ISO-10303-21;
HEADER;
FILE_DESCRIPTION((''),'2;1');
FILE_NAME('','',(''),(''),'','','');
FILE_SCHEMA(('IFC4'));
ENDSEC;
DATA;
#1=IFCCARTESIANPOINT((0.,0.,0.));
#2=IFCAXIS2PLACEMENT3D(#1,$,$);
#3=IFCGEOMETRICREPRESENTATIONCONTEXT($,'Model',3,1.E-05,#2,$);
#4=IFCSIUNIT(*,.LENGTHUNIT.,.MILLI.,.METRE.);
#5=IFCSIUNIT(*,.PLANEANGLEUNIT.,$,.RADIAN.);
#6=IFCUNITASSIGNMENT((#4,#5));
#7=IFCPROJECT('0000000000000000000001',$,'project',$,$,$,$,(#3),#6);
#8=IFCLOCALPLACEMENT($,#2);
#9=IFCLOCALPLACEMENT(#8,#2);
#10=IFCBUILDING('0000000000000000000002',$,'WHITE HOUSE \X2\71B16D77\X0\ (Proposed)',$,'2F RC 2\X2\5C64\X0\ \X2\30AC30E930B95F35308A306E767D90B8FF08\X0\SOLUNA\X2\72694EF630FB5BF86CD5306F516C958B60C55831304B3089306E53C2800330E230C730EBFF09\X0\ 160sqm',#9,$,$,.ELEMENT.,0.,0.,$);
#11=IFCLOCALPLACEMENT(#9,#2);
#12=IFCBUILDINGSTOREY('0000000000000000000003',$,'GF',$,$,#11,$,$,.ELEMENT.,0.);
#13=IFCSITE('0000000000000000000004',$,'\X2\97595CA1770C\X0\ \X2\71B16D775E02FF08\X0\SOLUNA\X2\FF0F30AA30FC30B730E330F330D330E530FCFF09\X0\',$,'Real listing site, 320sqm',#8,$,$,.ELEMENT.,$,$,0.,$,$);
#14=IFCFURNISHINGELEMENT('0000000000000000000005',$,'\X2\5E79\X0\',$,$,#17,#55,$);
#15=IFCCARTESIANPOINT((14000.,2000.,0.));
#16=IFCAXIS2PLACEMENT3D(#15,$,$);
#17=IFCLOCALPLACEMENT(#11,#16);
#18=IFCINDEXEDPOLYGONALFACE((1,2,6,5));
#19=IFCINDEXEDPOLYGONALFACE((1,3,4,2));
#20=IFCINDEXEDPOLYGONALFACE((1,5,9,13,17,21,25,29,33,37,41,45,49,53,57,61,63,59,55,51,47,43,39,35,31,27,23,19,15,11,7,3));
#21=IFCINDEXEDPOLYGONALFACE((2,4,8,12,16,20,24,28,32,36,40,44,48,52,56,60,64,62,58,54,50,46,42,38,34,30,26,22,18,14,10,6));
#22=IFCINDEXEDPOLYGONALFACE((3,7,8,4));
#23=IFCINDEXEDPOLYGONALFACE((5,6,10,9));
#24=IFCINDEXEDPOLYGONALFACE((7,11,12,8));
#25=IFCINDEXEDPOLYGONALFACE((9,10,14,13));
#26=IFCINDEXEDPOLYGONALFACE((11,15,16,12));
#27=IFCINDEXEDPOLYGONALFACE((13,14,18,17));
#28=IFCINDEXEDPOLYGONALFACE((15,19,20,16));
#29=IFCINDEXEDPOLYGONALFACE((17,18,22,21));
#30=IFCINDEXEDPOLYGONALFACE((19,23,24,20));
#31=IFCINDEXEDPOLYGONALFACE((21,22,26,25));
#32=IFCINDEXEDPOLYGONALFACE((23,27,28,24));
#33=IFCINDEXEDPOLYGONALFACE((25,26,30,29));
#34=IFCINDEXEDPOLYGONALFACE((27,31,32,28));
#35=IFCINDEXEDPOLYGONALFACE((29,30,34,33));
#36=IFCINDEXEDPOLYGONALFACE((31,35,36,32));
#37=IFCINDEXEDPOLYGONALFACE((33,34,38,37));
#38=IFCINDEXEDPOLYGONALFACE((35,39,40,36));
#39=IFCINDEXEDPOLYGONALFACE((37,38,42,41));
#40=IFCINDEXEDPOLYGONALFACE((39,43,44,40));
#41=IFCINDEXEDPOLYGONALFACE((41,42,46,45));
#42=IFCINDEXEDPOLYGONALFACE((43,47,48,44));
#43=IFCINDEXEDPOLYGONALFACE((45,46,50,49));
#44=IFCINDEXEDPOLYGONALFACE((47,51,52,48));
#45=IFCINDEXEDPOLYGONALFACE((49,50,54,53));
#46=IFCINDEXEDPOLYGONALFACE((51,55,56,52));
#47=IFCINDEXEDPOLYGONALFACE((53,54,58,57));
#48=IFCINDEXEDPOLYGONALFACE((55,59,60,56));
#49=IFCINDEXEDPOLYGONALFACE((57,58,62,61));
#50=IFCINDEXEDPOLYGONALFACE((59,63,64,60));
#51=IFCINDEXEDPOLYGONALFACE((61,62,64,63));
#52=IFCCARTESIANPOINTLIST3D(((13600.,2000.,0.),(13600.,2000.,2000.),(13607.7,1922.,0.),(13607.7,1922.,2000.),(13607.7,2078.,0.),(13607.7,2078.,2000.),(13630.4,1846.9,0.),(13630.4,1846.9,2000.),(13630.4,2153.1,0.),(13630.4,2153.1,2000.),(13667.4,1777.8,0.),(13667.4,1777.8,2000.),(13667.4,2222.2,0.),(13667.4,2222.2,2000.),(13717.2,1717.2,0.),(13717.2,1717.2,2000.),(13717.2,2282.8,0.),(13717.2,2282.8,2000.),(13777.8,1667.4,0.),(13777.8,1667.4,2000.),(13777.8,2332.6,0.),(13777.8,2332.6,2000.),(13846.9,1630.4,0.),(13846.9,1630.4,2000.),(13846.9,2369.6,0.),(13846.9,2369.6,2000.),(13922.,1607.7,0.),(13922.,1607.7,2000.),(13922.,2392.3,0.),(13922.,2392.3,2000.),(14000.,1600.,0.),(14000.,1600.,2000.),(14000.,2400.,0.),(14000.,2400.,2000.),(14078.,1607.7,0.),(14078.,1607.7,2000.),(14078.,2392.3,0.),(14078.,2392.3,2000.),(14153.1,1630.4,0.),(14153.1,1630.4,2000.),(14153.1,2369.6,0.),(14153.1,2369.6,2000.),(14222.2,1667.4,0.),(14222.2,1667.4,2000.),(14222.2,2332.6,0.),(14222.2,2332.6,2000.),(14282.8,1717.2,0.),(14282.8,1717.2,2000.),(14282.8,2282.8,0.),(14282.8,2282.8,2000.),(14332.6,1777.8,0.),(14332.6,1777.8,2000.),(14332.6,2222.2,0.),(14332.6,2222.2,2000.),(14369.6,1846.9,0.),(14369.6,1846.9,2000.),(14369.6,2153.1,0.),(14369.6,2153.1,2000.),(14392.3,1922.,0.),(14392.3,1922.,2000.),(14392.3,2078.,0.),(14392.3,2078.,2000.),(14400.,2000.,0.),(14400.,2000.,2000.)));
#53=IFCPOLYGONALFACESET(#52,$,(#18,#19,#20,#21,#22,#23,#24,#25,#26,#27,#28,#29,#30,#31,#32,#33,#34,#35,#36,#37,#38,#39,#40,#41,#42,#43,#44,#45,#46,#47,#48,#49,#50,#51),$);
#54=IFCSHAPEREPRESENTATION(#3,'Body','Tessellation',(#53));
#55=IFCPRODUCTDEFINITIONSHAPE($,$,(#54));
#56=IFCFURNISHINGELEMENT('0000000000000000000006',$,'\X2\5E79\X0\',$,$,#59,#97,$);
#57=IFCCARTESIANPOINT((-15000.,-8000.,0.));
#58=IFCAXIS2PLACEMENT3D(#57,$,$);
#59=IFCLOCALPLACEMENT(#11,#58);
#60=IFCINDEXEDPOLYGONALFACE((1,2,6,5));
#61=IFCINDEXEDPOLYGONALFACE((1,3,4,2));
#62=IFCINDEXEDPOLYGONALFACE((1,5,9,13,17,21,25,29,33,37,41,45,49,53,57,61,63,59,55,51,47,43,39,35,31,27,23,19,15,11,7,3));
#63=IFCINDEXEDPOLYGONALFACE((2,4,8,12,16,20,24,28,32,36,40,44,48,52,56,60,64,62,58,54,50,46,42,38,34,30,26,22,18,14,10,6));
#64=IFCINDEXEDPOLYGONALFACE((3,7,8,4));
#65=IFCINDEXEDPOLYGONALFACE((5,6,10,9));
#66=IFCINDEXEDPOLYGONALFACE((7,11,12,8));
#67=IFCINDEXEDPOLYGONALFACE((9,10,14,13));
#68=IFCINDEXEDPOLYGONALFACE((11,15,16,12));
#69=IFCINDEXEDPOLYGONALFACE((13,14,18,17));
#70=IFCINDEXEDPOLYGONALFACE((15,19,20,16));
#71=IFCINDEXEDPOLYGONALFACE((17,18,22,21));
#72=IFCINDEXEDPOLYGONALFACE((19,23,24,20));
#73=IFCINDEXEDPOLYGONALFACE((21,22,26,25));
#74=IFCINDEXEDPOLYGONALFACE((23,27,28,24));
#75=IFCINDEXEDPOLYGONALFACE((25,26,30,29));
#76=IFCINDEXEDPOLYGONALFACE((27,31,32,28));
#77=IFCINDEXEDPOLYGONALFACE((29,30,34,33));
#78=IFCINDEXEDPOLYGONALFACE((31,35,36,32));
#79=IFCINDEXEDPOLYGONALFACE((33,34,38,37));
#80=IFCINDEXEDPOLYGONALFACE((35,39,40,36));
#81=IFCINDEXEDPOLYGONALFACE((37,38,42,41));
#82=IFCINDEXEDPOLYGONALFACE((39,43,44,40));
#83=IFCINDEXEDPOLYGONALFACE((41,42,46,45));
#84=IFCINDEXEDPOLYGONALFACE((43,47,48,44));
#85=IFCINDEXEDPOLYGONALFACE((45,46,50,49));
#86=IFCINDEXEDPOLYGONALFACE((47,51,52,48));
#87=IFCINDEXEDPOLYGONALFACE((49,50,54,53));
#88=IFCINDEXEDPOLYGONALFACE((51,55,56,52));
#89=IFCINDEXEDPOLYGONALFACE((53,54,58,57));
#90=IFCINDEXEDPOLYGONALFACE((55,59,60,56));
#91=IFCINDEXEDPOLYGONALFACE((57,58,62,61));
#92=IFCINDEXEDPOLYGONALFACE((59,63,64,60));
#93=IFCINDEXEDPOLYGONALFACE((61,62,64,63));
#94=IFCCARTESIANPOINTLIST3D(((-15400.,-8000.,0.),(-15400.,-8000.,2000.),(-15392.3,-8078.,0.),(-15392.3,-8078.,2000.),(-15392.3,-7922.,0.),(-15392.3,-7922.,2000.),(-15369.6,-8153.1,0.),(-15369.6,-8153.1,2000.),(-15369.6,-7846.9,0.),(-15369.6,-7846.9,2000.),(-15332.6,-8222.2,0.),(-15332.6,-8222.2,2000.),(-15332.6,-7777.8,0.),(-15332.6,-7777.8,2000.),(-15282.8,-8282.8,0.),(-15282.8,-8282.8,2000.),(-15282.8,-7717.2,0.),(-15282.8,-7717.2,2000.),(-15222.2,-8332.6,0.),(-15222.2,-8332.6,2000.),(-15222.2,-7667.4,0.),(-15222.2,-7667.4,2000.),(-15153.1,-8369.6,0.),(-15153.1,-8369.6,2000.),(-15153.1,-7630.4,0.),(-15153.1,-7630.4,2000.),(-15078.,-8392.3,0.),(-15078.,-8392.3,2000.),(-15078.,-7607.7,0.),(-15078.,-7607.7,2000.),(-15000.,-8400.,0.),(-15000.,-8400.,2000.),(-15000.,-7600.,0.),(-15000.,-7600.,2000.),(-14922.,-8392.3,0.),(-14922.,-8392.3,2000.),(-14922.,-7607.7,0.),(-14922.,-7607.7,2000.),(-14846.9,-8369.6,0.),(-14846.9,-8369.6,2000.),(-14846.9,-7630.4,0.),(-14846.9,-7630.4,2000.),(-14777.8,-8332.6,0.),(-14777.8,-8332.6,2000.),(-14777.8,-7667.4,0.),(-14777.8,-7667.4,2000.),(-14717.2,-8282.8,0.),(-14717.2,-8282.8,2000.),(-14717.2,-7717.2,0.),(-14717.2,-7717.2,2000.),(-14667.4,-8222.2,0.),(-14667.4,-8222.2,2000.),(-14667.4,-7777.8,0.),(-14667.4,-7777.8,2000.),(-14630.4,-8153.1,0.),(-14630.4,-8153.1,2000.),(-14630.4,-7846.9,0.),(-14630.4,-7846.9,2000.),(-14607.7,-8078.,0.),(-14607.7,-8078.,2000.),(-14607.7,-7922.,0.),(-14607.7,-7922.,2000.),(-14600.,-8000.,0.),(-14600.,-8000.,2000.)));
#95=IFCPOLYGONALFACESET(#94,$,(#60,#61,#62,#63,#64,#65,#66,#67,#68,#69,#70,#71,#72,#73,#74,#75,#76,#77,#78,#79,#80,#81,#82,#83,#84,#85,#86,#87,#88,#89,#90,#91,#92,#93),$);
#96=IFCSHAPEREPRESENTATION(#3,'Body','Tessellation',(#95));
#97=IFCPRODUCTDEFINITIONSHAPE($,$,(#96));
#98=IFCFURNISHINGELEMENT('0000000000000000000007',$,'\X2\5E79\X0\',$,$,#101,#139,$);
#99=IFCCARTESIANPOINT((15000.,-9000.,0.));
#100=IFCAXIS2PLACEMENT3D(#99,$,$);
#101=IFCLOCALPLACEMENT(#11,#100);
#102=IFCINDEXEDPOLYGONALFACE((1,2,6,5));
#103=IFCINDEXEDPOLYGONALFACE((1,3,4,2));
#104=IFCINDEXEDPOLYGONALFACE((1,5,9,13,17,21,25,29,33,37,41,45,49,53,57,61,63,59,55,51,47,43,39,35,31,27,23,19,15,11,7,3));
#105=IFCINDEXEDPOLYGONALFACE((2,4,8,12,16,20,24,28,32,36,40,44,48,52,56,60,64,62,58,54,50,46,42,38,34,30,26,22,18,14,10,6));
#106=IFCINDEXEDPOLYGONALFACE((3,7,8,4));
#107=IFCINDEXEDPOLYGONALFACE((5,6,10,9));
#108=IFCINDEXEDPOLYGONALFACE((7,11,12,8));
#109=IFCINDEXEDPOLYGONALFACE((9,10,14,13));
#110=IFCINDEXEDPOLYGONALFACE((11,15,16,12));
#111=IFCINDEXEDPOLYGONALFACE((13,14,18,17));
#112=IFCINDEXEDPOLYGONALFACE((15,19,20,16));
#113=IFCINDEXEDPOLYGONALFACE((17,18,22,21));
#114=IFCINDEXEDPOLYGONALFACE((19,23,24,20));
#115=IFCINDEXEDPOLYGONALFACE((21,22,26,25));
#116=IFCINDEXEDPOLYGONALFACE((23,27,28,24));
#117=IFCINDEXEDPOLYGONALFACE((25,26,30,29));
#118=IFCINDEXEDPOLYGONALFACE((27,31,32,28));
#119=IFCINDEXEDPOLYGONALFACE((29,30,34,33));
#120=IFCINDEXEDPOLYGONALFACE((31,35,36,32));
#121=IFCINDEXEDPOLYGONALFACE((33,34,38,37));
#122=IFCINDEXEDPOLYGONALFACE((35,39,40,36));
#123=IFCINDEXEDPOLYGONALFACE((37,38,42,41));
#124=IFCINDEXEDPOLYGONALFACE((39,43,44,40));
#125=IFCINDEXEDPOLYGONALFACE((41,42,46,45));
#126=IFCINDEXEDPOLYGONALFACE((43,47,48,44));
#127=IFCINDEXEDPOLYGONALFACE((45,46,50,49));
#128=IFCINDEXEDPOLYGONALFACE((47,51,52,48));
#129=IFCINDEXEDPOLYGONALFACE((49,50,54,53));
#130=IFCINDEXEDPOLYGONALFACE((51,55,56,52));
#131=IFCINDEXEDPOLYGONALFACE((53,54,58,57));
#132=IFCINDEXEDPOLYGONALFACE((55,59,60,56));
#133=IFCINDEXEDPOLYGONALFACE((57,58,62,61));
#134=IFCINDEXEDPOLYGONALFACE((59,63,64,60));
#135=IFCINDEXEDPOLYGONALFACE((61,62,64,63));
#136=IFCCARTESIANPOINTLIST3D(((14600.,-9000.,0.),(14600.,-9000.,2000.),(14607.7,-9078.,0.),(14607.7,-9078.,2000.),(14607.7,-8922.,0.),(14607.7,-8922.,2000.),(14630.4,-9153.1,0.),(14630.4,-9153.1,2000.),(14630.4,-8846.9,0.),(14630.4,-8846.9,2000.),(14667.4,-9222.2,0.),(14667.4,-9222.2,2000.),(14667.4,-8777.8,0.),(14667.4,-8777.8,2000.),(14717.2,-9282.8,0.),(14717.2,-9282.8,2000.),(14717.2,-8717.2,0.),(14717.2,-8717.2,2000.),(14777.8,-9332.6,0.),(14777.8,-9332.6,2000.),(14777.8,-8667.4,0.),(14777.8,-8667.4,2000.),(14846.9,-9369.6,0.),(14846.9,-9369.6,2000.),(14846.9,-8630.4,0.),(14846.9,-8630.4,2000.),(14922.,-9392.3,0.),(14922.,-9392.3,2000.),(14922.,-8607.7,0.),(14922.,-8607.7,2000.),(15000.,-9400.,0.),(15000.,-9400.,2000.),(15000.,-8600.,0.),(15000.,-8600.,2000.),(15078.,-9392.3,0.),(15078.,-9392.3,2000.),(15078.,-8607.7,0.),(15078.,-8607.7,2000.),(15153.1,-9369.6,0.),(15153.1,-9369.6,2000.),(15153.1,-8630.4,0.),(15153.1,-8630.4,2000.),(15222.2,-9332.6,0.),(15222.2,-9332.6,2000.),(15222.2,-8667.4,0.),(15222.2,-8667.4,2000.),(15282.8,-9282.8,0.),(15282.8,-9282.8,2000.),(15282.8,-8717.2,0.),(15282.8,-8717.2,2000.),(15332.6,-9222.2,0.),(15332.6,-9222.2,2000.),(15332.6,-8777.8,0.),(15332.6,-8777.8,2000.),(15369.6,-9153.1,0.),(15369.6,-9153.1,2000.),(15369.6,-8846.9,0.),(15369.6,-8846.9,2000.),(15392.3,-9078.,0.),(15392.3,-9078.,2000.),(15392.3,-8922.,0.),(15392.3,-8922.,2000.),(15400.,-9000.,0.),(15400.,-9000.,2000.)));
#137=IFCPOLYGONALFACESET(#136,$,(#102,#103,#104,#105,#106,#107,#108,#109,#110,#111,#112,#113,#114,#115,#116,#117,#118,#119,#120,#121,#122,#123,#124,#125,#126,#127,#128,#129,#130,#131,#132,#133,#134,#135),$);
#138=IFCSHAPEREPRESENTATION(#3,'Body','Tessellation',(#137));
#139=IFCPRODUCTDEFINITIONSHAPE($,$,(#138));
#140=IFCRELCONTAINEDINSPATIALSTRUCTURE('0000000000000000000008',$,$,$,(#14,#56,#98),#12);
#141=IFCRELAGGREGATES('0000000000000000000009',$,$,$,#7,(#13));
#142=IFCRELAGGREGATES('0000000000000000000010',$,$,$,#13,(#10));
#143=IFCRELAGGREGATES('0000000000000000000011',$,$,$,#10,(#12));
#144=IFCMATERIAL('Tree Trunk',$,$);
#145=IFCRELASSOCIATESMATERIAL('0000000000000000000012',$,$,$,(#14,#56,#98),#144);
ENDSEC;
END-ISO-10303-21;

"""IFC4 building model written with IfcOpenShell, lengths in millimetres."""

from ifc_helpers import new_model, si_unit, frame, origin, origin_2d, place, context, project, spatial, circle, extrude, material, element, save


model = new_model("IFC4")

# Units and contexts
model_context = context("Model", 3, precision=1e-05, world=origin())
ifc_project = project(units=[si_unit("LENGTHUNIT", "METRE", prefix="MILLI"), si_unit("PLANEANGLEUNIT", "RADIAN")], contexts=[model_context])

# Site, building, storey
site_placement = place(None, origin())
site = spatial("IfcSite", under=ifc_project, at=site_placement, Name="静岡県 熱海市（SOLUNA／オーシャンビュー）", ObjectType="Real listing site, 320sqm", CompositionType="ELEMENT", RefElevation=0.0)
building_placement = place(site_placement, origin())
building = spatial("IfcBuilding", under=site, at=building_placement, Name="WHITE HOUSE 熱海 (Proposed)", ObjectType="2F RC 2層 ガラス張りの白邸（SOLUNA物件・寸法は公開情報からの参考モデル） 160sqm", CompositionType="ELEMENT", ElevationOfRefHeight=0.0, ElevationOfTerrain=0.0)
storey_placement = place(building_placement, origin())
storey = spatial("IfcBuildingStorey", under=building, at=storey_placement, Name="GF", CompositionType="ELEMENT", Elevation=0.0)

# Furnishing elements
ifc_material_1 = material(Name="Tree Trunk")
furnishing_1_placement = place(storey_placement, frame((14000.0, 2000.0, 0.0)))
element("IfcFurnishingElement", 1, at=furnishing_1_placement, inside=storey, material=ifc_material_1, Name="幹", context=model_context, shape_type="SweptSolid", body=[
    extrude(circle(Radius=400.0, at=origin_2d()), frame((14000.0, 2000.0, 0.0)), (0.0, 0.0, 1.0), 2000.0),
])
furnishing_2_placement = place(storey_placement, frame((-15000.0, -8000.0, 0.0)))
element("IfcFurnishingElement", 2, at=furnishing_2_placement, inside=storey, material=ifc_material_1, Name="幹", context=model_context, shape_type="SweptSolid", body=[
    extrude(circle(Radius=400.0, at=origin_2d()), frame((-15000.0, -8000.0, 0.0)), (0.0, 0.0, 1.0), 2000.0),
])
furnishing_3_placement = place(storey_placement, frame((15000.0, -9000.0, 0.0)))
element("IfcFurnishingElement", 3, at=furnishing_3_placement, inside=storey, material=ifc_material_1, Name="幹", context=model_context, shape_type="SweptSolid", body=[
    extrude(circle(Radius=400.0, at=origin_2d()), frame((15000.0, -9000.0, 0.0)), (0.0, 0.0, 1.0), 2000.0),
])

save(model, "model.ifc")
